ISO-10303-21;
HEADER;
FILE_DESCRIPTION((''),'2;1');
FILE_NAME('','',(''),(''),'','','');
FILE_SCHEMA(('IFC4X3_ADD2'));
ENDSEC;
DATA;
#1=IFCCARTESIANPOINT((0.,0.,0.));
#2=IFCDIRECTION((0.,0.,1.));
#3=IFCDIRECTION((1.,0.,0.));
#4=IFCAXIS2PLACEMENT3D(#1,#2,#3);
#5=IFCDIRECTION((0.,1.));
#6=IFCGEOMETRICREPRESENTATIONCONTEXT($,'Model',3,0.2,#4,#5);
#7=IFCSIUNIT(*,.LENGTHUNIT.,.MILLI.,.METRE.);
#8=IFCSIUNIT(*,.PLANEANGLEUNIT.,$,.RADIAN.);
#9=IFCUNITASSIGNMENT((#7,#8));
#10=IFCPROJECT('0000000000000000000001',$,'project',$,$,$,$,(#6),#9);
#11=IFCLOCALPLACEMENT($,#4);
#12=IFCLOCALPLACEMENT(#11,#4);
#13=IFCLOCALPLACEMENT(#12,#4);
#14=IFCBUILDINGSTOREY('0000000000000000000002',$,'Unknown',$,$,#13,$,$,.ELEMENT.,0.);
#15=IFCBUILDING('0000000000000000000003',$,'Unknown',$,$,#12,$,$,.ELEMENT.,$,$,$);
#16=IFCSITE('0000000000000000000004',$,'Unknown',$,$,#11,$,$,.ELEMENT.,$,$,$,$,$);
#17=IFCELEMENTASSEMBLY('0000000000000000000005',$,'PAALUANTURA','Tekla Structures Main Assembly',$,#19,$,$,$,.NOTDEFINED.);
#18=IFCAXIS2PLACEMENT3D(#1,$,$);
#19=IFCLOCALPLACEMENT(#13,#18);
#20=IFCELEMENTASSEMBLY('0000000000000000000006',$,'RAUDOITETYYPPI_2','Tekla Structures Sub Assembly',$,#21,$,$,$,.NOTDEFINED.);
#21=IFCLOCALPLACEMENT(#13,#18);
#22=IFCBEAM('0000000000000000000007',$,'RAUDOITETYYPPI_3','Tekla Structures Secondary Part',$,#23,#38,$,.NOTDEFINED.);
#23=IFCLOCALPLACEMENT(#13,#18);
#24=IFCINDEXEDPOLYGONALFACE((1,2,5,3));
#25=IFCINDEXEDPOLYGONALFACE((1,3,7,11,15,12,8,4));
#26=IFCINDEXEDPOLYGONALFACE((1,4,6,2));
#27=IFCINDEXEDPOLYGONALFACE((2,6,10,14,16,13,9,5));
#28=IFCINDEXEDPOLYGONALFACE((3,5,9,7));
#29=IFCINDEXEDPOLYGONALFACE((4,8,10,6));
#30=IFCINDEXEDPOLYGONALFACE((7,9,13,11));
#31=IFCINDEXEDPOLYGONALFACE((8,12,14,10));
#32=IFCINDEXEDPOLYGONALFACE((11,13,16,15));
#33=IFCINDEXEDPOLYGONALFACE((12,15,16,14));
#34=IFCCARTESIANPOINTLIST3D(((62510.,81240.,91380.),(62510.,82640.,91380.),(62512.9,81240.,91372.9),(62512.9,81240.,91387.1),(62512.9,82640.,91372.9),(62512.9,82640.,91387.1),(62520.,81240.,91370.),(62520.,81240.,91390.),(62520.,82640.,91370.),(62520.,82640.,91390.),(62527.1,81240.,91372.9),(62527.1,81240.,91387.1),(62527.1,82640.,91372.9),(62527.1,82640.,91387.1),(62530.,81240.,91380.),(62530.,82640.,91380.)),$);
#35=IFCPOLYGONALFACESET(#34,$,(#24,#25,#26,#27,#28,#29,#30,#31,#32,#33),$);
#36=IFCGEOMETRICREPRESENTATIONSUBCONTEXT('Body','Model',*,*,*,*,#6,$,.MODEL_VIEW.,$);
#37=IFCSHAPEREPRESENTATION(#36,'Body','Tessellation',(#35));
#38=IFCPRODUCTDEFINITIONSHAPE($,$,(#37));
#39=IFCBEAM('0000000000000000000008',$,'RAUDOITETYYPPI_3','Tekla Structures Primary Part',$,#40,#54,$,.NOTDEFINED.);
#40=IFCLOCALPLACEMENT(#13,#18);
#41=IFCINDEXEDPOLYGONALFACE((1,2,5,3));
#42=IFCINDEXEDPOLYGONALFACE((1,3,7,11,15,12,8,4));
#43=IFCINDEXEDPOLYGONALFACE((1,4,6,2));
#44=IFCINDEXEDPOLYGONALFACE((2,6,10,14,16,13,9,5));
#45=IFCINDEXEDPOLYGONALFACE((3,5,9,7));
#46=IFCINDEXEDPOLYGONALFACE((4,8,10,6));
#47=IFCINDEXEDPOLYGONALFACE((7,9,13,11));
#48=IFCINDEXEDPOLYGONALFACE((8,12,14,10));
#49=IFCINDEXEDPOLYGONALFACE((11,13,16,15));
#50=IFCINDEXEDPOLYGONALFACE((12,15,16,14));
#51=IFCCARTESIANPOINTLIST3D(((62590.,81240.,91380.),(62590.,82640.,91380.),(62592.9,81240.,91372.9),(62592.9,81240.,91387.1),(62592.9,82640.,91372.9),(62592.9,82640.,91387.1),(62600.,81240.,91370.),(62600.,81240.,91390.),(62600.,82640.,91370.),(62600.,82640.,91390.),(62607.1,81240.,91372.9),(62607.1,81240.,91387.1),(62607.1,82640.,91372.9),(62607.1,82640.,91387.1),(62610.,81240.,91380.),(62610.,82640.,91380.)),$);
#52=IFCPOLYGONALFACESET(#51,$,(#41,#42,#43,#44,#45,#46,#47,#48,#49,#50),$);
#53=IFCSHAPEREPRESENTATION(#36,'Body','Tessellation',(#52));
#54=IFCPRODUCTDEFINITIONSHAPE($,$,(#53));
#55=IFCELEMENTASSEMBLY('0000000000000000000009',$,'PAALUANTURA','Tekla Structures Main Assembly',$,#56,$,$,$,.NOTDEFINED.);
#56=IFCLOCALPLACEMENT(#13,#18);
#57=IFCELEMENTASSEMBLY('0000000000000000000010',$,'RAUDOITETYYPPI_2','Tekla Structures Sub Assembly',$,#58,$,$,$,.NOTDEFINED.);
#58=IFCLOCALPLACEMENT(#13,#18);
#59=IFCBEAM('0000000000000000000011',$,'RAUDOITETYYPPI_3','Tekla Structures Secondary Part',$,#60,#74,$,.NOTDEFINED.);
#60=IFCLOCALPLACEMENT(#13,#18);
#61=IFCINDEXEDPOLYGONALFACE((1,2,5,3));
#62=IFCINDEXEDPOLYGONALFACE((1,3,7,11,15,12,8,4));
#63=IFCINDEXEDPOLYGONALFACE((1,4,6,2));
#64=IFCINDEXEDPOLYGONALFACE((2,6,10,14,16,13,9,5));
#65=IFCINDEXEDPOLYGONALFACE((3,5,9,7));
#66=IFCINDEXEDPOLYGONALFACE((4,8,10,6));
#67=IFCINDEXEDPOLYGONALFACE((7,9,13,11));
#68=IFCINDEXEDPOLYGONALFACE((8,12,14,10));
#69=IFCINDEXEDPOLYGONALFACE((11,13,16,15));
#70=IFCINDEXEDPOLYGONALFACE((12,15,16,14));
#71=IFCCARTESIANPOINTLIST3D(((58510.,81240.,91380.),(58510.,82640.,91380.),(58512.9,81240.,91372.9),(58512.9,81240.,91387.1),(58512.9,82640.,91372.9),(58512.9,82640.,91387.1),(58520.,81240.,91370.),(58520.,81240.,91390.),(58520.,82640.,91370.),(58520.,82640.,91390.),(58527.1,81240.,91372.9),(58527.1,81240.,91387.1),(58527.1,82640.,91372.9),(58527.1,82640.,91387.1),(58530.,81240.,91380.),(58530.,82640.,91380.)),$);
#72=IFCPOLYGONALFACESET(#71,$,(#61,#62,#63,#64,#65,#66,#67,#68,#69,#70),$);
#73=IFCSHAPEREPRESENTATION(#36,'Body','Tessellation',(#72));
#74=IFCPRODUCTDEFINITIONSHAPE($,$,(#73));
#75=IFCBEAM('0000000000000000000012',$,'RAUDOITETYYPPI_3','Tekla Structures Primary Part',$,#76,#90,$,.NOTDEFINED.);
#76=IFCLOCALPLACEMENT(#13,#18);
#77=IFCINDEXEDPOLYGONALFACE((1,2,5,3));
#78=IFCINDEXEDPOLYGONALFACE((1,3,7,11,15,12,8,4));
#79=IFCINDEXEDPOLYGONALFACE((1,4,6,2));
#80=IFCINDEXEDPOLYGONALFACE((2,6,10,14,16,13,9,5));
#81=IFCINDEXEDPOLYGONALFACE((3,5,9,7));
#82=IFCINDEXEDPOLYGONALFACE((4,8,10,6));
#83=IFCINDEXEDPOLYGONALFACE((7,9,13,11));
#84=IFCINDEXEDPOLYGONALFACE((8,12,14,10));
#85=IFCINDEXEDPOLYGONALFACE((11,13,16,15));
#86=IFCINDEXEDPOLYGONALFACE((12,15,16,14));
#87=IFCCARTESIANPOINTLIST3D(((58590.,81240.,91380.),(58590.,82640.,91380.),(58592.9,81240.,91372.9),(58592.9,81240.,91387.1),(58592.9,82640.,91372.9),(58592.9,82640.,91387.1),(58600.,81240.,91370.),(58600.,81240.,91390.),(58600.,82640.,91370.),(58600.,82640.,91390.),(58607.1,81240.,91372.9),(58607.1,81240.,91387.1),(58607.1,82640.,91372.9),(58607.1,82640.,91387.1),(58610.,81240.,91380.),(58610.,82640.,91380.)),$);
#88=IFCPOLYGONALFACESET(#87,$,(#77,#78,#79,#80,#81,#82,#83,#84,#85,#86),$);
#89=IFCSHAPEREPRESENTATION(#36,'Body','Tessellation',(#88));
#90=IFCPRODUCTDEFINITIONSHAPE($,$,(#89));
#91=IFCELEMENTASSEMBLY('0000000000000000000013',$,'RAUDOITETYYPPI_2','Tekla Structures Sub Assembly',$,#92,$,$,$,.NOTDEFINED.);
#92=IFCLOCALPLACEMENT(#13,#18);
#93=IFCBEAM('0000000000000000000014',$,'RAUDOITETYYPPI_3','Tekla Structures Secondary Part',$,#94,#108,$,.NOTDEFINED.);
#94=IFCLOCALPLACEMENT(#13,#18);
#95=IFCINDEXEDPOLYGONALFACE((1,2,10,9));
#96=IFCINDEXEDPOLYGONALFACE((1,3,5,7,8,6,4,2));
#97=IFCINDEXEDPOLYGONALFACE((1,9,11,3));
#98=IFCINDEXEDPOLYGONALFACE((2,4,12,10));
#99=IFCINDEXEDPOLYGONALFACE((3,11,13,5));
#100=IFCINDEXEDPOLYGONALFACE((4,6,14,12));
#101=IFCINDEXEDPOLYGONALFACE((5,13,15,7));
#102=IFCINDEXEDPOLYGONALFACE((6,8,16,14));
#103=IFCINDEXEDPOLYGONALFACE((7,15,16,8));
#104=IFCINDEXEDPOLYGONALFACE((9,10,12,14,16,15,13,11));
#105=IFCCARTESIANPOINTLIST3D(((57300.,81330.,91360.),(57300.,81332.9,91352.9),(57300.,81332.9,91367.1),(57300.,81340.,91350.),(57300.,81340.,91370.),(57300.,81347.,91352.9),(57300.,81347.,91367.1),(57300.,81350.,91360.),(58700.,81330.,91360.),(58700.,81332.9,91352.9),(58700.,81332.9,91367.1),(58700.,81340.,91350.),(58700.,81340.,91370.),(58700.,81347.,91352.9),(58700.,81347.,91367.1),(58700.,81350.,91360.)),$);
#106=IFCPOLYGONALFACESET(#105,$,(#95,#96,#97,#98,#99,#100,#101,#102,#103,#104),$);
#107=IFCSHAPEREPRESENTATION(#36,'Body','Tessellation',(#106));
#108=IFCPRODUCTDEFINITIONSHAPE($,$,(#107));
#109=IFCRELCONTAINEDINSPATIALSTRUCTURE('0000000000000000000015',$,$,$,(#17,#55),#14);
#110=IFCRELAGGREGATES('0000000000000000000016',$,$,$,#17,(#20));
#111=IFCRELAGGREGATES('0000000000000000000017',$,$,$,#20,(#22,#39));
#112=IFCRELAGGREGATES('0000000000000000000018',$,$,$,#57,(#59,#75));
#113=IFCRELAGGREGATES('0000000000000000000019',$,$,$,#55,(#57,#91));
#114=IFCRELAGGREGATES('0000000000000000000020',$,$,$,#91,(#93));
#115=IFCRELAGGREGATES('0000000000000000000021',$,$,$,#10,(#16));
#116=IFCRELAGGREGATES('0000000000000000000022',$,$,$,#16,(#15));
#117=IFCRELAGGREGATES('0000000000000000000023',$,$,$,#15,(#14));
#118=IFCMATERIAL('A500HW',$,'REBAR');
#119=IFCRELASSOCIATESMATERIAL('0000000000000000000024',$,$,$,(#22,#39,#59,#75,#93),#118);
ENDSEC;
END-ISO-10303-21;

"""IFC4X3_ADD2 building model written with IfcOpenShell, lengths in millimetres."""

from ifc_helpers import new_model, si_unit, direction, frame, origin_with_axes, place, context, subcontext, project, spatial, line, indexed_curve, outline, extrude, material, element, aggregate, save


model = new_model("IFC4X3_ADD2")

# Units and contexts
model_context = context("Model", 3, precision=0.2, world=origin_with_axes(), true_north=direction((0.0, 1.0)))
body_context = subcontext(model_context, "Body", "Model", "MODEL_VIEW")
ifc_project = project(units=[si_unit("LENGTHUNIT", "METRE", prefix="MILLI"), si_unit("PLANEANGLEUNIT", "RADIAN")], contexts=[model_context])

# Site, building, storey
site_placement = place(None, origin_with_axes())
site = spatial("IfcSite", under=ifc_project, at=site_placement, Name="Unknown", CompositionType="ELEMENT")
building_placement = place(site_placement, origin_with_axes())
building = spatial("IfcBuilding", under=site, at=building_placement, Name="Unknown", CompositionType="ELEMENT")
storey_placement = place(building_placement, origin_with_axes())
storey = spatial("IfcBuildingStorey", under=building, at=storey_placement, Name="Unknown", CompositionType="ELEMENT", Elevation=0.0)

# Element assemblies, beams
assembly_1_placement = place(storey_placement, frame((62800.0, 81940.0, 92100.0), z_axis=(0.0, -1.0, 0.0), x_axis=(0.0, 0.0, -1.0)))
assembly_1 = element("IfcElementAssembly", 1, at=assembly_1_placement, inside=storey, Name="PAALUANTURA", Description="Tekla Structures Main Assembly", PredefinedType="NOTDEFINED")
ifc_material_1 = material(Name="A500HW", Category="REBAR")
assembly_2_placement = place(assembly_1_placement, frame((720.0, -200.0, 700.0), z_axis=(0.0, -1.0, 0.0), x_axis=(0.0, 0.0, -1.0)))
assembly_2 = element("IfcElementAssembly", 2, at=assembly_2_placement, Name="RAUDOITETYYPPI_2", Description="Tekla Structures Sub Assembly", PredefinedType="NOTDEFINED")
aggregate(assembly_1, [assembly_2])
beam_1_placement = place(assembly_2_placement, frame((0.0, 0.0, 80.0), z_axis=(0.0, 0.0, 1.0), x_axis=(1.0, 0.0, 0.0)))
beam_1 = element("IfcBeam", 3, at=beam_1_placement, material=ifc_material_1, Name="RAUDOITETYYPPI_3", Description="Tekla Structures Secondary Part", PredefinedType="NOTDEFINED", context=body_context, shape_type="SolidModel", body=[
    extrude(outline(indexed_curve([(10.0, 0.0), (7.1, 7.1), (0.0, 10.0), (-7.1, 7.1), (-10.0, 0.0), (-7.1, -7.1), (0.0, -10.0), (7.1, -7.1)], segments=[line(1, 2, 3, 4, 5, 6, 7, 8, 1)])), frame((0.0, 0.0, 0.0), z_axis=(-1.0, 0.0, 0.0), x_axis=(0.0, 0.0, 1.0)), (0.0, 0.0, -1.0), 1400.0),
])
beam_2_placement = place(assembly_2_placement, origin_with_axes())
beam_2 = element("IfcBeam", 4, at=beam_2_placement, material=ifc_material_1, Name="RAUDOITETYYPPI_3", Description="Tekla Structures Primary Part", PredefinedType="NOTDEFINED", context=body_context, shape_type="SolidModel", body=[
    extrude(outline(indexed_curve([(10.0, 0.0), (7.1, 7.1), (0.0, 10.0), (-7.1, 7.1), (-10.0, 0.0), (-7.1, -7.1), (0.0, -10.0), (7.1, -7.1)], segments=[line(1, 2, 3, 4, 5, 6, 7, 8, 1)])), frame((0.0, 0.0, 0.0), z_axis=(-1.0, 0.0, 0.0), x_axis=(0.0, 0.0, 1.0)), (0.0, 0.0, -1.0), 1400.0),
])
aggregate(assembly_2, [beam_1, beam_2])
assembly_3_placement = place(storey_placement, frame((58000.0, 81940.0, 92100.0), z_axis=(0.0, -1.0, 0.0), x_axis=(0.0, 0.0, -1.0)))
assembly_3 = element("IfcElementAssembly", 5, at=assembly_3_placement, inside=storey, Name="PAALUANTURA", Description="Tekla Structures Main Assembly", PredefinedType="NOTDEFINED")
assembly_4_placement = place(assembly_3_placement, frame((720.0, 600.0, 700.0), z_axis=(0.0, -1.0, 0.0), x_axis=(0.0, 0.0, -1.0)))
assembly_4 = element("IfcElementAssembly", 6, at=assembly_4_placement, Name="RAUDOITETYYPPI_2", Description="Tekla Structures Sub Assembly", PredefinedType="NOTDEFINED")
beam_3_placement = place(assembly_4_placement, frame((0.0, 0.0, 80.0), z_axis=(0.0, 0.0, 1.0), x_axis=(1.0, 0.0, 0.0)))
beam_3 = element("IfcBeam", 7, at=beam_3_placement, material=ifc_material_1, Name="RAUDOITETYYPPI_3", Description="Tekla Structures Secondary Part", PredefinedType="NOTDEFINED", context=body_context, shape_type="SolidModel", body=[
    extrude(outline(indexed_curve([(10.0, 0.0), (7.1, 7.1), (0.0, 10.0), (-7.1, 7.1), (-10.0, 0.0), (-7.1, -7.1), (0.0, -10.0), (7.1, -7.1)], segments=[line(1, 2, 3, 4, 5, 6, 7, 8, 1)])), frame((0.0, 0.0, 0.0), z_axis=(-1.0, 0.0, 0.0), x_axis=(0.0, 0.0, 1.0)), (0.0, 0.0, -1.0), 1400.0),
])
beam_4_placement = place(assembly_4_placement, origin_with_axes())
beam_4 = element("IfcBeam", 8, at=beam_4_placement, material=ifc_material_1, Name="RAUDOITETYYPPI_3", Description="Tekla Structures Primary Part", PredefinedType="NOTDEFINED", context=body_context, shape_type="SolidModel", body=[
    extrude(outline(indexed_curve([(10.0, 0.0), (7.1, 7.1), (0.0, 10.0), (-7.1, 7.1), (-10.0, 0.0), (-7.1, -7.1), (0.0, -10.0), (7.1, -7.1)], segments=[line(1, 2, 3, 4, 5, 6, 7, 8, 1)])), frame((0.0, 0.0, 0.0), z_axis=(-1.0, 0.0, 0.0), x_axis=(0.0, 0.0, 1.0)), (0.0, 0.0, -1.0), 1400.0),
])
aggregate(assembly_4, [beam_3, beam_4])
assembly_5_placement = place(assembly_3_placement, frame((740.0, 700.0, 200.0), z_axis=(-1.0, 0.0, 0.0), x_axis=(0.0, -1.0, 0.0)))
assembly_5 = element("IfcElementAssembly", 9, at=assembly_5_placement, Name="RAUDOITETYYPPI_2", Description="Tekla Structures Sub Assembly", PredefinedType="NOTDEFINED")
aggregate(assembly_3, [assembly_4, assembly_5])
beam_5_placement = place(assembly_5_placement, frame((0.0, 400.0, 0.0), z_axis=(0.0, 0.0, 1.0), x_axis=(1.0, 0.0, 0.0)))
beam_5 = element("IfcBeam", 10, at=beam_5_placement, material=ifc_material_1, Name="RAUDOITETYYPPI_3", Description="Tekla Structures Secondary Part", PredefinedType="NOTDEFINED", context=body_context, shape_type="SolidModel", body=[
    extrude(outline(indexed_curve([(10.0, 0.0), (7.1, 7.1), (0.0, 10.0), (-7.1, 7.1), (-10.0, 0.0), (-7.1, -7.1), (0.0, -10.0), (7.1, -7.1)], segments=[line(1, 2, 3, 4, 5, 6, 7, 8, 1)])), frame((0.0, 0.0, 0.0), z_axis=(-1.0, 0.0, 0.0), x_axis=(0.0, 0.0, 1.0)), (0.0, 0.0, -1.0), 1400.0),
])
aggregate(assembly_5, [beam_5])

save(model, "model.ifc")
